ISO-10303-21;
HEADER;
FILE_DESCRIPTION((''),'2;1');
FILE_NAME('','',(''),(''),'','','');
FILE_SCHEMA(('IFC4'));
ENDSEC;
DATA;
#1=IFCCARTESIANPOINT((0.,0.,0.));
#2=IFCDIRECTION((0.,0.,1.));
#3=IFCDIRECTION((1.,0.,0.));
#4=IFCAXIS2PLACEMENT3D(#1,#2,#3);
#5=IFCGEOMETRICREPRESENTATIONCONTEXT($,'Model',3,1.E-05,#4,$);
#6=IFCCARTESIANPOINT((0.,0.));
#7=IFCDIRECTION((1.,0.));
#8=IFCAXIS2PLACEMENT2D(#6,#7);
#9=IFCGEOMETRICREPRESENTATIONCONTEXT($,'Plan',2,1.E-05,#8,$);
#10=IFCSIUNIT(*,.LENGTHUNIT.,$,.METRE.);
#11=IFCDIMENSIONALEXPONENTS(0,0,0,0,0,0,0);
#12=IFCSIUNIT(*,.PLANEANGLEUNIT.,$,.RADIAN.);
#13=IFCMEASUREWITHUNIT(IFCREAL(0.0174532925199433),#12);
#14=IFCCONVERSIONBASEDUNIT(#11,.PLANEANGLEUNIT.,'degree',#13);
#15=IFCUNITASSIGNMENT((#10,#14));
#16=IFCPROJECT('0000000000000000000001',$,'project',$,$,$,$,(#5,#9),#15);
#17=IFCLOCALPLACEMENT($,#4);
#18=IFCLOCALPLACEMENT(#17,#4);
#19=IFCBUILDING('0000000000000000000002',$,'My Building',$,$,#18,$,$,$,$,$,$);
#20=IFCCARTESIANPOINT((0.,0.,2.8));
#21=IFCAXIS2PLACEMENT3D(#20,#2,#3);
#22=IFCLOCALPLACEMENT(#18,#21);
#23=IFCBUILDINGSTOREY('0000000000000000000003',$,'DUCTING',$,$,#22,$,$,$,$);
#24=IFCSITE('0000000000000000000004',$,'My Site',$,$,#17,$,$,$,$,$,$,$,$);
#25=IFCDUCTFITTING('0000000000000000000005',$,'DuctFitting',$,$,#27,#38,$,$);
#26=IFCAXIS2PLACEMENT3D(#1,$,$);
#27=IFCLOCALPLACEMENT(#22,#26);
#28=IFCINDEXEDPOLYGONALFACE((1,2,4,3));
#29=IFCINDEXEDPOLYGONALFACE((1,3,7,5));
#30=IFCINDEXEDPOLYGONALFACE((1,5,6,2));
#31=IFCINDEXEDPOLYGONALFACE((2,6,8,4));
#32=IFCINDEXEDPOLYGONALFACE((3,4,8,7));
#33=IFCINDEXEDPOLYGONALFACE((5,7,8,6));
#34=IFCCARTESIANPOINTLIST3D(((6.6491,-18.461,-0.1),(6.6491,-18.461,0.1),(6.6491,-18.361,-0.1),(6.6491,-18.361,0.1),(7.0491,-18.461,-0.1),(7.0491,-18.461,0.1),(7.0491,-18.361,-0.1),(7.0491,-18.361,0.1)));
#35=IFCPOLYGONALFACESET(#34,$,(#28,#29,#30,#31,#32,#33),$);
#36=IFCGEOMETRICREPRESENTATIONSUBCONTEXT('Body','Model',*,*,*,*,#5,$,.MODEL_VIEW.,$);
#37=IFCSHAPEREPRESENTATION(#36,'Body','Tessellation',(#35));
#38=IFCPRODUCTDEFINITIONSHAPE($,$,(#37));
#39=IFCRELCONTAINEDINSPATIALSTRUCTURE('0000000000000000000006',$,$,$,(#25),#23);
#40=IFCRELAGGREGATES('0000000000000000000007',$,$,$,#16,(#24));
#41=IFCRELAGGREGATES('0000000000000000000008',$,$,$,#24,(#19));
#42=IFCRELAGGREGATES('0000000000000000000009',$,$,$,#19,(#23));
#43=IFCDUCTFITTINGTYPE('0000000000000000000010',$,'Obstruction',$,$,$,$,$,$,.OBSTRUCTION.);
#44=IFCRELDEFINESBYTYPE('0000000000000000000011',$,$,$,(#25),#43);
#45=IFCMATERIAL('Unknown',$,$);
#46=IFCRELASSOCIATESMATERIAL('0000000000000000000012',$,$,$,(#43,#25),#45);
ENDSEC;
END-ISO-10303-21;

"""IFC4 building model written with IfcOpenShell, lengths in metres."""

from ifc_helpers import new_model, entity, si_unit, converted_unit, frame, origin_with_axes, origin_2d_with_axis, place, context, subcontext, project, spatial, rectangle, extrude, material, material_profile, profile_set, profile_usage, type_object, element, save


model = new_model("IFC4")

# Units and contexts
model_context = context("Model", 3, precision=1e-05, world=origin_with_axes())
plan_context = context("Plan", 2, precision=1e-05, world=origin_2d_with_axis())
body_context = subcontext(model_context, "Body", "Model", "MODEL_VIEW")
ifc_project = project(units=[si_unit("LENGTHUNIT", "METRE"), converted_unit("PLANEANGLEUNIT", "degree", entity("IfcReal", 0.0174532925199433), si_unit("PLANEANGLEUNIT", "RADIAN"), dimensions=[0, 0, 0, 0, 0, 0, 0])], contexts=[model_context, plan_context])

# Site, building, storey
site_placement = place(None, origin_with_axes())
site = spatial("IfcSite", under=ifc_project, at=site_placement, Name="My Site")
building_placement = place(site_placement, origin_with_axes())
building = spatial("IfcBuilding", under=site, at=building_placement, Name="My Building")
storey_placement = place(building_placement, frame((0.0, 0.0, 2.8), z_axis=(0.0, 0.0, 1.0), x_axis=(1.0, 0.0, 0.0)))
storey = spatial("IfcBuildingStorey", under=building, at=storey_placement, Name="DUCTING")

# Shared definitions
ifc_material = material(Name="Unknown")

# Duct fitting
ifc_material_profile_1 = material_profile(ifc_material, rectangle(XDim=0.4, YDim=0.2))
ifc_profile_set_1 = profile_set([ifc_material_profile_1])
duct_fitting_type_1 = type_object("IfcDuctFittingType", Name="Obstruction", PredefinedType="OBSTRUCTION", material=ifc_profile_set_1)
ifc_profile_usage_1 = profile_usage(ifc_profile_set_1, cardinal=5)
duct_fitting_1_placement = place(storey_placement, frame((6.8491, -18.361, 0.0), z_axis=(0.0, -1.0, 0.0), x_axis=(1.0, 0.0, 0.0)))
element("IfcDuctFitting", 1, at=duct_fitting_1_placement, inside=storey, type_object=duct_fitting_type_1, material=ifc_profile_usage_1, Name="DuctFitting", context=body_context, shape_type="SweptSolid", body=[
    extrude(rectangle(XDim=0.4, YDim=0.2), origin_with_axes(), (0.0, 0.0, 1.0), 0.1),
])

save(model, "model.ifc")
